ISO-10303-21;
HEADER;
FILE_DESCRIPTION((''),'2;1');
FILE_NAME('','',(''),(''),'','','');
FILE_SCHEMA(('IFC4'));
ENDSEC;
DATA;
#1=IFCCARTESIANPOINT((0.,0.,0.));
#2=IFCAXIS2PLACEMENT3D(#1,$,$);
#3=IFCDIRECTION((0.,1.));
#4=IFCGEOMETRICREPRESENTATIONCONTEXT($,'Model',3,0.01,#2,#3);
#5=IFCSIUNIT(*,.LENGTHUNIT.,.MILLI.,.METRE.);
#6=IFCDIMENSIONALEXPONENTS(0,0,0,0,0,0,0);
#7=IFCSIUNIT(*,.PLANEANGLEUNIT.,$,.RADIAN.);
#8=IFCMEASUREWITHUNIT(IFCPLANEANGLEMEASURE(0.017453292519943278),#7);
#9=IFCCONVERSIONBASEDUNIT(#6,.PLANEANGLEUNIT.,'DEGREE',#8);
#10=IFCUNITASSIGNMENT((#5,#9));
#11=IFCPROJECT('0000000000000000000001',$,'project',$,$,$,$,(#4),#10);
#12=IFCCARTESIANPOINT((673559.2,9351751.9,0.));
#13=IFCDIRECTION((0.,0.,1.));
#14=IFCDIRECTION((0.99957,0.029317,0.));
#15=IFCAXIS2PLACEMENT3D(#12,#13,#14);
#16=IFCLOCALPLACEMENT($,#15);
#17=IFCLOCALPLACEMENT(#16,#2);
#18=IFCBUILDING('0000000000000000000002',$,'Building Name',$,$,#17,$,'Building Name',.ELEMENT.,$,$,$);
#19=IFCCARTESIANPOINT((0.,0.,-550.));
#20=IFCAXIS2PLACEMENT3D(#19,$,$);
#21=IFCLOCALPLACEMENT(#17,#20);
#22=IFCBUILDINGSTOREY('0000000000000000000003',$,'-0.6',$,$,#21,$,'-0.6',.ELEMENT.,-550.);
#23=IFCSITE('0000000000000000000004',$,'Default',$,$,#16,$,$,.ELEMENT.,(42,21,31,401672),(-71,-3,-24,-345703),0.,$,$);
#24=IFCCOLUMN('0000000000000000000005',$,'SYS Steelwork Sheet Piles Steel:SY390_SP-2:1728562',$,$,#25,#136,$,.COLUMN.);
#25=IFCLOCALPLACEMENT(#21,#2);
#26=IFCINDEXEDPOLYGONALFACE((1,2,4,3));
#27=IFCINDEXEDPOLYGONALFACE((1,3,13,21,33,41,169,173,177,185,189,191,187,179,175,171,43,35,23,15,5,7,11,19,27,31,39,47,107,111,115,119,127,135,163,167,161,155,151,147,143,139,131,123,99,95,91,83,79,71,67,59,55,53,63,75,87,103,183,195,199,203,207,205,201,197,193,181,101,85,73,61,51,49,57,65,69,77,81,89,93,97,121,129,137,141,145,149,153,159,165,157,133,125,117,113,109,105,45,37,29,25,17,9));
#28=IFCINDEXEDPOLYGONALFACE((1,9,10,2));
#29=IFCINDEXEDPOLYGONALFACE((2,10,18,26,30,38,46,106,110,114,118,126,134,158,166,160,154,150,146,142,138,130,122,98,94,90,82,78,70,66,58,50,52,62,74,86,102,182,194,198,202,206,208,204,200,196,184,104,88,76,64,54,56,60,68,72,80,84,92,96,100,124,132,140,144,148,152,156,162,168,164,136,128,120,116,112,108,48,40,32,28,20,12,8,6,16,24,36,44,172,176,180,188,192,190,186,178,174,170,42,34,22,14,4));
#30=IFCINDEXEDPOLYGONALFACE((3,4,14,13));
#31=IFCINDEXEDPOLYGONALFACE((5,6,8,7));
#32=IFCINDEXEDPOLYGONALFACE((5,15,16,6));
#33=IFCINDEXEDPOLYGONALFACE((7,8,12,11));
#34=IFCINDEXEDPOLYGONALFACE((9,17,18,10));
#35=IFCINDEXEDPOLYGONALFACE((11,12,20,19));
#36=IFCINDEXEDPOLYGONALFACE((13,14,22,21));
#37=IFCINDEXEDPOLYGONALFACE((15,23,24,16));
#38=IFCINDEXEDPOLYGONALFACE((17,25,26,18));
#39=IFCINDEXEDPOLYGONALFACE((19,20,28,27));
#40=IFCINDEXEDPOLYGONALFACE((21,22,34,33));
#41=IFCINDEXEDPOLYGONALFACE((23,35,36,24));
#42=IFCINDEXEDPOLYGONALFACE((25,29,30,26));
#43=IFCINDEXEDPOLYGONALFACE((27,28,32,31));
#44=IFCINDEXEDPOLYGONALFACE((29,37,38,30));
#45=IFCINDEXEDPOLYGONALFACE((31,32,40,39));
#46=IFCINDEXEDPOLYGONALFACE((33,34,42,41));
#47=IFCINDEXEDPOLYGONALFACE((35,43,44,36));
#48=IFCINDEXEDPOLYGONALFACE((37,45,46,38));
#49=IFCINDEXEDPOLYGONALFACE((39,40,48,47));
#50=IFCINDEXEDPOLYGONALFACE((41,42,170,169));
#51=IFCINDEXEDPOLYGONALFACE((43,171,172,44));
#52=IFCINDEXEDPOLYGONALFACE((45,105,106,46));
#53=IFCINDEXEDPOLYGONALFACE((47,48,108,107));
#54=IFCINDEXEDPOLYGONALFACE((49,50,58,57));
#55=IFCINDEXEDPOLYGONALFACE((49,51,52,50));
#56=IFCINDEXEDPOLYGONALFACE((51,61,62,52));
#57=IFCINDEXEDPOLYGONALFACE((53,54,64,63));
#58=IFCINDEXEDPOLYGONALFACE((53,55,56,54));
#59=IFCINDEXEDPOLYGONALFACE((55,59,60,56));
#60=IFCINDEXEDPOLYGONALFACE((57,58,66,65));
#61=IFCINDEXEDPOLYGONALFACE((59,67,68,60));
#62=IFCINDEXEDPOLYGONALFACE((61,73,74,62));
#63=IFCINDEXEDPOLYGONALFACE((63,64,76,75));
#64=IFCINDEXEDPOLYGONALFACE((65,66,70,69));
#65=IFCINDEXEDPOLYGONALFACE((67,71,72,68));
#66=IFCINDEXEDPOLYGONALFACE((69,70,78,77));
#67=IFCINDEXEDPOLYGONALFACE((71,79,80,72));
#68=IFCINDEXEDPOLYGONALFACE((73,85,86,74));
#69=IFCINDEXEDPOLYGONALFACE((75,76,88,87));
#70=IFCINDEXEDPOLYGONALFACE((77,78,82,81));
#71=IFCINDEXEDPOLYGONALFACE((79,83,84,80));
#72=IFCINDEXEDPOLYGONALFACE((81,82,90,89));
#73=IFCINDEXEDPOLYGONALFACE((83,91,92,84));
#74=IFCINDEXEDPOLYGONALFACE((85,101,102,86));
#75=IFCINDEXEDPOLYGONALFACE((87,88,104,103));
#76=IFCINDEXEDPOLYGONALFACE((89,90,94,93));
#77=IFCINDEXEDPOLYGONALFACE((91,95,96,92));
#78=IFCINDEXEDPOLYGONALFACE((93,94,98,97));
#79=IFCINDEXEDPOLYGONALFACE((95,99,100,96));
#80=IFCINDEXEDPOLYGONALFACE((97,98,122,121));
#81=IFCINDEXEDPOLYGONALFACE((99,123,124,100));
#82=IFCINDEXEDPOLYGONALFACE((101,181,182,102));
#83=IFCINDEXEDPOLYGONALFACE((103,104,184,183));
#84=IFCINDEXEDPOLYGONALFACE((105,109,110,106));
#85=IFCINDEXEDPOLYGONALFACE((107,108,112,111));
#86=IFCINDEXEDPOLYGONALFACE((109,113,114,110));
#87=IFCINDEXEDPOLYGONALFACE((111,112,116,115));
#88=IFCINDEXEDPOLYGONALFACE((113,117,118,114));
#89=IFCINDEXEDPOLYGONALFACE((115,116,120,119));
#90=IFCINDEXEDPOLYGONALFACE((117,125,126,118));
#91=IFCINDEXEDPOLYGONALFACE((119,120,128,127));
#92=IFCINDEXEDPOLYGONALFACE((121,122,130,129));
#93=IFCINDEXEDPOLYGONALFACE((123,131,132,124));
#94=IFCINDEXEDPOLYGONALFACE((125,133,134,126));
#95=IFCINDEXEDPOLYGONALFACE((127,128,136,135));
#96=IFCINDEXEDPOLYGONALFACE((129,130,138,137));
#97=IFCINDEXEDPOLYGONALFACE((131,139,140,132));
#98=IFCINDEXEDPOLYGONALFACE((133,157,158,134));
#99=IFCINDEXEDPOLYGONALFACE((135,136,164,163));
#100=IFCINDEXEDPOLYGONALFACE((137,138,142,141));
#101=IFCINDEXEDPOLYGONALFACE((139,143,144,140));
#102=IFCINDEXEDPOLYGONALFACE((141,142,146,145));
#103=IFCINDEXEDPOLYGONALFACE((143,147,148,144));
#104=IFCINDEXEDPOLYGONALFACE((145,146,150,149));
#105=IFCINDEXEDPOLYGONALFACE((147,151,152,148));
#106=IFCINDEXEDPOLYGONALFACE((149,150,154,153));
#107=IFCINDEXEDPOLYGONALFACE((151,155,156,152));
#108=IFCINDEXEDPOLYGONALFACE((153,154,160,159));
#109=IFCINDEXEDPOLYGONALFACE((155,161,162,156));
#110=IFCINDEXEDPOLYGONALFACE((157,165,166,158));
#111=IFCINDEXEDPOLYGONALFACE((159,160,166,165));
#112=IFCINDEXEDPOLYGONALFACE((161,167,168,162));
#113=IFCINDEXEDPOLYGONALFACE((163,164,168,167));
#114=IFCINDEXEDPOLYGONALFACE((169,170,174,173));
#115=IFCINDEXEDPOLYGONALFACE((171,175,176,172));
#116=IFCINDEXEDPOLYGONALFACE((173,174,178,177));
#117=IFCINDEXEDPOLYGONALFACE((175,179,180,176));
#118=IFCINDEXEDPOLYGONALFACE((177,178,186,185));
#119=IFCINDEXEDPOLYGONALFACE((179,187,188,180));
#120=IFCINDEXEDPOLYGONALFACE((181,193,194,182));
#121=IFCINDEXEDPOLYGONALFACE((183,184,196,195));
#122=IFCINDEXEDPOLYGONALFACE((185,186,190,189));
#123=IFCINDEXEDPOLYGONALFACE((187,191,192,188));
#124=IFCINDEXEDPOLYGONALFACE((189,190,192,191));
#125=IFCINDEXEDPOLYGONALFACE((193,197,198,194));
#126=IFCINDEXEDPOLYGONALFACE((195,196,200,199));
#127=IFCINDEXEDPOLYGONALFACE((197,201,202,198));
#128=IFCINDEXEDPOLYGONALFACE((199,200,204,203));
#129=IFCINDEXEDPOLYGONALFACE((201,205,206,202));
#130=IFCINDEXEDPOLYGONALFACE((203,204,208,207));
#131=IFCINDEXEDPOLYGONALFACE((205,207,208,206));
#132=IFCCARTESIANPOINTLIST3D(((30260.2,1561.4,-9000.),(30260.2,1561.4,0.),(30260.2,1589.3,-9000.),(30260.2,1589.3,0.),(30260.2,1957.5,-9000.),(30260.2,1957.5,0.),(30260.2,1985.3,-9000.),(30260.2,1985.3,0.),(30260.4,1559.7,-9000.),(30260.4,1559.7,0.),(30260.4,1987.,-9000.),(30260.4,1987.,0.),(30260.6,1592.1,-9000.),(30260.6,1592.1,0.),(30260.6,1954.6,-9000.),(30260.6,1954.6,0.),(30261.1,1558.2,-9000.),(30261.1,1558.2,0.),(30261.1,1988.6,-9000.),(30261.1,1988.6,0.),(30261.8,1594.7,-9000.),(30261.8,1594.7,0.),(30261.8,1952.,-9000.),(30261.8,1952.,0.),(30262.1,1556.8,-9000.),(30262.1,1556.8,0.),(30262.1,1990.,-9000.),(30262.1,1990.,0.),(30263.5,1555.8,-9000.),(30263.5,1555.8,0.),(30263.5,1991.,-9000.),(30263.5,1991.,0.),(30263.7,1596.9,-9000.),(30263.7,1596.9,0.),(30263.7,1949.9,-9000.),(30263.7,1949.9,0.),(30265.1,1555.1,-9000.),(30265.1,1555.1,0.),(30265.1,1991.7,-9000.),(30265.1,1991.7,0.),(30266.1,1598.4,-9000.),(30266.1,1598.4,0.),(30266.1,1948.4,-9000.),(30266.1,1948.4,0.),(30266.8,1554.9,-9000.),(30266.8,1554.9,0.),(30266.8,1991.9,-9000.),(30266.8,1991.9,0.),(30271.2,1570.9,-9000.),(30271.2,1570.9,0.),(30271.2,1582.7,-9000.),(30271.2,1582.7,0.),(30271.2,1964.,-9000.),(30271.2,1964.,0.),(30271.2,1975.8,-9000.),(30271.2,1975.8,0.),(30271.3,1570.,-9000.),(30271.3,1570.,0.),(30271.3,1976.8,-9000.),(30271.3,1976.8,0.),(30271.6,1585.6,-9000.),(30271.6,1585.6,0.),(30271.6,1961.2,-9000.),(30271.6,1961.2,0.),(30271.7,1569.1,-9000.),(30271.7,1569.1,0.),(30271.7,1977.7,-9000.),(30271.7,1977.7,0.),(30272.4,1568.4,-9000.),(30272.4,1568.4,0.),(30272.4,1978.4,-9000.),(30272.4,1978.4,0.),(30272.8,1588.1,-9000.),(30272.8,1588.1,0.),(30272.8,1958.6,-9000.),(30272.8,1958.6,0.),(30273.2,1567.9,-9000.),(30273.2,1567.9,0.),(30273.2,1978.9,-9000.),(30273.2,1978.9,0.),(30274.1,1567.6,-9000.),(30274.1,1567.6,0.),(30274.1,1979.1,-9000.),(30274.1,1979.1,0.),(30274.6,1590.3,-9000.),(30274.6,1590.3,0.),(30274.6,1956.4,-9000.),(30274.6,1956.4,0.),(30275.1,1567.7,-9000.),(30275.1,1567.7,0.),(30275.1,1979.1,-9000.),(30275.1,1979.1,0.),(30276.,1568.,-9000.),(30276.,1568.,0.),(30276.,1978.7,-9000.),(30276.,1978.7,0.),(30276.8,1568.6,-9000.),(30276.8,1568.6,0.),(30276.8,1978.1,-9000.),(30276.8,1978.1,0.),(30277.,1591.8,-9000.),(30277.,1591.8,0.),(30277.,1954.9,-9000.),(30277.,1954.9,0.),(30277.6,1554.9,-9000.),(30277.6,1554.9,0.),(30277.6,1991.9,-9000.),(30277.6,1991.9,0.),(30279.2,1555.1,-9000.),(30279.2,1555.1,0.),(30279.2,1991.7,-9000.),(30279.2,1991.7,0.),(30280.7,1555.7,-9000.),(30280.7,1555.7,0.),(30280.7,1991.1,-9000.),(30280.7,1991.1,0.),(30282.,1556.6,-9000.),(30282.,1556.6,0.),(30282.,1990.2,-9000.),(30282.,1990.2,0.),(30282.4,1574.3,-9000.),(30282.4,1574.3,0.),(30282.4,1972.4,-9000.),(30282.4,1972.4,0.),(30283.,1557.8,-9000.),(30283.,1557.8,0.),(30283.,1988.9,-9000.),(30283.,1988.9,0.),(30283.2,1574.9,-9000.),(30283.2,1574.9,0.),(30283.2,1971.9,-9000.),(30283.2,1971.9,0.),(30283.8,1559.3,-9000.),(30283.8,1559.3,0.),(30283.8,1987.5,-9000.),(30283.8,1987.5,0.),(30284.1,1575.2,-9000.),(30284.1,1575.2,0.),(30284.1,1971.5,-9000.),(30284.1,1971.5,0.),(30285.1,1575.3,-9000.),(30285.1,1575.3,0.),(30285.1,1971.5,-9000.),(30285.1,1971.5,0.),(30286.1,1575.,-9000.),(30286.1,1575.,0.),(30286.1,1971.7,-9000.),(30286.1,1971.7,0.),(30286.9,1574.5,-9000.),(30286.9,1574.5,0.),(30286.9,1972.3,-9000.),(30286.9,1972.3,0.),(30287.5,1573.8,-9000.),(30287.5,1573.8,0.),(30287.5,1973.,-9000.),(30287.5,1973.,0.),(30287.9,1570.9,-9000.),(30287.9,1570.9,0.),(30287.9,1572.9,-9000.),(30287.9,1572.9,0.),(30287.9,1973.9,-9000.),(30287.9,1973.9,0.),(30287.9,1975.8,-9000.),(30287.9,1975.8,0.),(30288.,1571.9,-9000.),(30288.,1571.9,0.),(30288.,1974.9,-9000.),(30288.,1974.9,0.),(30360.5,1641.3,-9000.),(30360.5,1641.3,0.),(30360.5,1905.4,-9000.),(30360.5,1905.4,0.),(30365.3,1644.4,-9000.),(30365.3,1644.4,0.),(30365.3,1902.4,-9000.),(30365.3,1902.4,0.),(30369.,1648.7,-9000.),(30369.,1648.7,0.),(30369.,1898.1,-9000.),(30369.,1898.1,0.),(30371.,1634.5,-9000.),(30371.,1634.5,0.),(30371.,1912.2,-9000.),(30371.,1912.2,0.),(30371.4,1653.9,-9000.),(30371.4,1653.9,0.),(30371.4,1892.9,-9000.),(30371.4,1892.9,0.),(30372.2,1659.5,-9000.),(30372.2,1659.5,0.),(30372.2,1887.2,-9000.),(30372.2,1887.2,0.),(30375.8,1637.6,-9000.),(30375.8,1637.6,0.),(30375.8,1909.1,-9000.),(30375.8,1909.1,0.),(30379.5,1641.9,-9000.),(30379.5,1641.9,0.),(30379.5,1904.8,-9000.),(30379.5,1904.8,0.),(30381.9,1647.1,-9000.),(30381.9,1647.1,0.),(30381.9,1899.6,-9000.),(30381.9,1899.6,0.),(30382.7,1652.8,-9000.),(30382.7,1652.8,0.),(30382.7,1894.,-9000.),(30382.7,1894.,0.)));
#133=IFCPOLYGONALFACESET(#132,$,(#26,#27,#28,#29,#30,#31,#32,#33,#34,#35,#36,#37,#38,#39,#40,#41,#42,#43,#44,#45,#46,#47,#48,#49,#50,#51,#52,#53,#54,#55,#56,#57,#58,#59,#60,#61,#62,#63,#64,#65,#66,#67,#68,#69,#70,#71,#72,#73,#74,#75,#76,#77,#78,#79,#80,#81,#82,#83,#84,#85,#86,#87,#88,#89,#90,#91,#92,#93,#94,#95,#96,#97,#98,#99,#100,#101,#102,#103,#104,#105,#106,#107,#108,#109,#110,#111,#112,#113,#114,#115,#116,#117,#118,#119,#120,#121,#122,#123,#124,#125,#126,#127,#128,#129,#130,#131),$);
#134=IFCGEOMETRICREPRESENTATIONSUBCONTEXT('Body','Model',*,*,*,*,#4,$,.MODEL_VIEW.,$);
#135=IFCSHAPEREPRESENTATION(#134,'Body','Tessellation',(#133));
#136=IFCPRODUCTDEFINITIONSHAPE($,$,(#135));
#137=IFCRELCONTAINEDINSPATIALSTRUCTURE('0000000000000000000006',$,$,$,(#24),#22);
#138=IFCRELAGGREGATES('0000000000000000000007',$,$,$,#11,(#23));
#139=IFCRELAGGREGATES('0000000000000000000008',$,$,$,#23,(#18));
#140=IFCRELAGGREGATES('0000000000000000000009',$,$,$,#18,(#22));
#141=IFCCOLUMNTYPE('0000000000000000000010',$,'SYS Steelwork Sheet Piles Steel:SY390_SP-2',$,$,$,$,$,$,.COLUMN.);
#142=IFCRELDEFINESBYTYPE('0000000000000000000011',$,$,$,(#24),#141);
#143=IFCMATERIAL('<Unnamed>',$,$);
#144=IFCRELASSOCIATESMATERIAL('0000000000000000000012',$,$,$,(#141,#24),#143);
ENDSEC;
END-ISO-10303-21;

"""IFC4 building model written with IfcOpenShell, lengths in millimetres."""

from ifc_helpers import new_model, entity, si_unit, converted_unit, direction, frame, origin, place, context, subcontext, project, spatial, line, arc, indexed_curve, outline, extrude, source, transform, mapped, material, type_object, type_shapes, element, save


model = new_model("IFC4")

# Units and contexts
model_context = context("Model", 3, precision=0.01, world=origin(), true_north=direction((0.0, 1.0)))
body_context = subcontext(model_context, "Body", "Model", "MODEL_VIEW")
ifc_project = project(units=[si_unit("LENGTHUNIT", "METRE", prefix="MILLI"), converted_unit("PLANEANGLEUNIT", "DEGREE", entity("IfcPlaneAngleMeasure", 0.017453292519943278), si_unit("PLANEANGLEUNIT", "RADIAN"), dimensions=[0, 0, 0, 0, 0, 0, 0])], contexts=[model_context])

# Site, building, storey
site_placement = place(None, frame((673559.2, 9351751.9, 0.0), z_axis=(0.0, 0.0, 1.0), x_axis=(0.99957, 0.029317, 0.0)))
site = spatial("IfcSite", under=ifc_project, at=site_placement, Name="Default", CompositionType="ELEMENT", RefLatitude=(42, 21, 31, 401672), RefLongitude=(-71, -3, -24, -345703), RefElevation=0.0)
building_placement = place(site_placement, origin())
building = spatial("IfcBuilding", under=site, at=building_placement, Name="Building Name", LongName="Building Name", CompositionType="ELEMENT")
storey_placement = place(building_placement, frame((0.0, 0.0, -550.0)))
storey = spatial("IfcBuildingStorey", under=building, at=storey_placement, Name="-0.6", LongName="-0.6", CompositionType="ELEMENT", Elevation=-550.0)

# Column
ifc_material_1 = material(Name="<Unnamed>")
column_type = type_object("IfcColumnType", Name="SYS Steelwork Sheet Piles Steel:SY390_SP-2", PredefinedType="COLUMN", material=ifc_material_1)
shared_shape_1 = source(origin(), body_context, "Body", "SweptSolid", [
    extrude(outline(indexed_curve([(-120.6, 84.7), (-131.4, 81.6), (-138.8, 73.0), (-181.5, -20.9), (-185.2, -25.2), (-190.6, -26.8), (-202.5, -26.8), (-205.5, -24.8), (-204.8, -21.2), (-199.1, -15.5), (-198.6, -11.5), (-202.5, -10.1), (-214.1, -14.2), (-217.3, -16.6), (-218.5, -20.4), (-218.5, -31.2), (-216.6, -35.8), (-211.9, -37.8), (-184.1, -37.8), (-178.7, -36.2), (-175.0, -31.9), (-132.1, 62.5), (-124.7, 71.1), (-113.9, 74.2), (113.9, 74.2), (124.7, 71.1), (132.1, 62.5), (175.0, -31.9), (178.7, -36.2), (184.1, -37.8), (211.9, -37.8), (216.6, -35.8), (218.5, -31.2), (218.5, -20.4), (217.3, -16.6), (214.1, -14.2), (202.5, -10.1), (198.6, -11.5), (199.1, -15.5), (204.8, -21.2), (205.5, -24.8), (202.5, -26.8), (190.6, -26.8), (185.2, -25.2), (181.5, -20.9), (138.8, 73.0), (131.4, 81.6), (120.6, 84.7)], segments=[arc(1, 2, 3), line(3, 4), arc(4, 5, 6), line(6, 7), arc(7, 8, 9), line(9, 10), arc(10, 11, 12), line(12, 13), arc(13, 14, 15), line(15, 16), arc(16, 17, 18), line(18, 19), arc(19, 20, 21), line(21, 22), arc(22, 23, 24), line(24, 25), arc(25, 26, 27), line(27, 28), arc(28, 29, 30), line(30, 31), arc(31, 32, 33), line(33, 34), arc(34, 35, 36), line(36, 37), arc(37, 38, 39), line(39, 40), arc(40, 41, 42), line(42, 43), arc(43, 44, 45), line(45, 46), arc(46, 47, 48), line(48, 1)], self_intersect=False)), frame((0.0, 15.3, -9550.0)), (0.0, 0.0, 1.0), 9000.0),
])
type_shapes(column_type, [shared_shape_1])
for number, where, z_axis, x_axis, name in (
    (1, (30282.7, 1773.4, 550.0), (0.0, 0.0, 1.0), (0.0, -1.0, 0.0), "SYS Steelwork Sheet Piles Steel:SY390_SP-2:1728562"),
):
    element("IfcColumn", number, at=place(storey_placement, frame(where, z_axis=z_axis, x_axis=x_axis)), inside=storey, type_object=column_type, material=ifc_material_1, Name=name, PredefinedType="COLUMN", context=body_context, shape_type="MappedRepresentation", body=[
        mapped(shared_shape_1, transform((0.0, 0.0, 0.0), scale=1.0)),
    ])

save(model, "model.ifc")
